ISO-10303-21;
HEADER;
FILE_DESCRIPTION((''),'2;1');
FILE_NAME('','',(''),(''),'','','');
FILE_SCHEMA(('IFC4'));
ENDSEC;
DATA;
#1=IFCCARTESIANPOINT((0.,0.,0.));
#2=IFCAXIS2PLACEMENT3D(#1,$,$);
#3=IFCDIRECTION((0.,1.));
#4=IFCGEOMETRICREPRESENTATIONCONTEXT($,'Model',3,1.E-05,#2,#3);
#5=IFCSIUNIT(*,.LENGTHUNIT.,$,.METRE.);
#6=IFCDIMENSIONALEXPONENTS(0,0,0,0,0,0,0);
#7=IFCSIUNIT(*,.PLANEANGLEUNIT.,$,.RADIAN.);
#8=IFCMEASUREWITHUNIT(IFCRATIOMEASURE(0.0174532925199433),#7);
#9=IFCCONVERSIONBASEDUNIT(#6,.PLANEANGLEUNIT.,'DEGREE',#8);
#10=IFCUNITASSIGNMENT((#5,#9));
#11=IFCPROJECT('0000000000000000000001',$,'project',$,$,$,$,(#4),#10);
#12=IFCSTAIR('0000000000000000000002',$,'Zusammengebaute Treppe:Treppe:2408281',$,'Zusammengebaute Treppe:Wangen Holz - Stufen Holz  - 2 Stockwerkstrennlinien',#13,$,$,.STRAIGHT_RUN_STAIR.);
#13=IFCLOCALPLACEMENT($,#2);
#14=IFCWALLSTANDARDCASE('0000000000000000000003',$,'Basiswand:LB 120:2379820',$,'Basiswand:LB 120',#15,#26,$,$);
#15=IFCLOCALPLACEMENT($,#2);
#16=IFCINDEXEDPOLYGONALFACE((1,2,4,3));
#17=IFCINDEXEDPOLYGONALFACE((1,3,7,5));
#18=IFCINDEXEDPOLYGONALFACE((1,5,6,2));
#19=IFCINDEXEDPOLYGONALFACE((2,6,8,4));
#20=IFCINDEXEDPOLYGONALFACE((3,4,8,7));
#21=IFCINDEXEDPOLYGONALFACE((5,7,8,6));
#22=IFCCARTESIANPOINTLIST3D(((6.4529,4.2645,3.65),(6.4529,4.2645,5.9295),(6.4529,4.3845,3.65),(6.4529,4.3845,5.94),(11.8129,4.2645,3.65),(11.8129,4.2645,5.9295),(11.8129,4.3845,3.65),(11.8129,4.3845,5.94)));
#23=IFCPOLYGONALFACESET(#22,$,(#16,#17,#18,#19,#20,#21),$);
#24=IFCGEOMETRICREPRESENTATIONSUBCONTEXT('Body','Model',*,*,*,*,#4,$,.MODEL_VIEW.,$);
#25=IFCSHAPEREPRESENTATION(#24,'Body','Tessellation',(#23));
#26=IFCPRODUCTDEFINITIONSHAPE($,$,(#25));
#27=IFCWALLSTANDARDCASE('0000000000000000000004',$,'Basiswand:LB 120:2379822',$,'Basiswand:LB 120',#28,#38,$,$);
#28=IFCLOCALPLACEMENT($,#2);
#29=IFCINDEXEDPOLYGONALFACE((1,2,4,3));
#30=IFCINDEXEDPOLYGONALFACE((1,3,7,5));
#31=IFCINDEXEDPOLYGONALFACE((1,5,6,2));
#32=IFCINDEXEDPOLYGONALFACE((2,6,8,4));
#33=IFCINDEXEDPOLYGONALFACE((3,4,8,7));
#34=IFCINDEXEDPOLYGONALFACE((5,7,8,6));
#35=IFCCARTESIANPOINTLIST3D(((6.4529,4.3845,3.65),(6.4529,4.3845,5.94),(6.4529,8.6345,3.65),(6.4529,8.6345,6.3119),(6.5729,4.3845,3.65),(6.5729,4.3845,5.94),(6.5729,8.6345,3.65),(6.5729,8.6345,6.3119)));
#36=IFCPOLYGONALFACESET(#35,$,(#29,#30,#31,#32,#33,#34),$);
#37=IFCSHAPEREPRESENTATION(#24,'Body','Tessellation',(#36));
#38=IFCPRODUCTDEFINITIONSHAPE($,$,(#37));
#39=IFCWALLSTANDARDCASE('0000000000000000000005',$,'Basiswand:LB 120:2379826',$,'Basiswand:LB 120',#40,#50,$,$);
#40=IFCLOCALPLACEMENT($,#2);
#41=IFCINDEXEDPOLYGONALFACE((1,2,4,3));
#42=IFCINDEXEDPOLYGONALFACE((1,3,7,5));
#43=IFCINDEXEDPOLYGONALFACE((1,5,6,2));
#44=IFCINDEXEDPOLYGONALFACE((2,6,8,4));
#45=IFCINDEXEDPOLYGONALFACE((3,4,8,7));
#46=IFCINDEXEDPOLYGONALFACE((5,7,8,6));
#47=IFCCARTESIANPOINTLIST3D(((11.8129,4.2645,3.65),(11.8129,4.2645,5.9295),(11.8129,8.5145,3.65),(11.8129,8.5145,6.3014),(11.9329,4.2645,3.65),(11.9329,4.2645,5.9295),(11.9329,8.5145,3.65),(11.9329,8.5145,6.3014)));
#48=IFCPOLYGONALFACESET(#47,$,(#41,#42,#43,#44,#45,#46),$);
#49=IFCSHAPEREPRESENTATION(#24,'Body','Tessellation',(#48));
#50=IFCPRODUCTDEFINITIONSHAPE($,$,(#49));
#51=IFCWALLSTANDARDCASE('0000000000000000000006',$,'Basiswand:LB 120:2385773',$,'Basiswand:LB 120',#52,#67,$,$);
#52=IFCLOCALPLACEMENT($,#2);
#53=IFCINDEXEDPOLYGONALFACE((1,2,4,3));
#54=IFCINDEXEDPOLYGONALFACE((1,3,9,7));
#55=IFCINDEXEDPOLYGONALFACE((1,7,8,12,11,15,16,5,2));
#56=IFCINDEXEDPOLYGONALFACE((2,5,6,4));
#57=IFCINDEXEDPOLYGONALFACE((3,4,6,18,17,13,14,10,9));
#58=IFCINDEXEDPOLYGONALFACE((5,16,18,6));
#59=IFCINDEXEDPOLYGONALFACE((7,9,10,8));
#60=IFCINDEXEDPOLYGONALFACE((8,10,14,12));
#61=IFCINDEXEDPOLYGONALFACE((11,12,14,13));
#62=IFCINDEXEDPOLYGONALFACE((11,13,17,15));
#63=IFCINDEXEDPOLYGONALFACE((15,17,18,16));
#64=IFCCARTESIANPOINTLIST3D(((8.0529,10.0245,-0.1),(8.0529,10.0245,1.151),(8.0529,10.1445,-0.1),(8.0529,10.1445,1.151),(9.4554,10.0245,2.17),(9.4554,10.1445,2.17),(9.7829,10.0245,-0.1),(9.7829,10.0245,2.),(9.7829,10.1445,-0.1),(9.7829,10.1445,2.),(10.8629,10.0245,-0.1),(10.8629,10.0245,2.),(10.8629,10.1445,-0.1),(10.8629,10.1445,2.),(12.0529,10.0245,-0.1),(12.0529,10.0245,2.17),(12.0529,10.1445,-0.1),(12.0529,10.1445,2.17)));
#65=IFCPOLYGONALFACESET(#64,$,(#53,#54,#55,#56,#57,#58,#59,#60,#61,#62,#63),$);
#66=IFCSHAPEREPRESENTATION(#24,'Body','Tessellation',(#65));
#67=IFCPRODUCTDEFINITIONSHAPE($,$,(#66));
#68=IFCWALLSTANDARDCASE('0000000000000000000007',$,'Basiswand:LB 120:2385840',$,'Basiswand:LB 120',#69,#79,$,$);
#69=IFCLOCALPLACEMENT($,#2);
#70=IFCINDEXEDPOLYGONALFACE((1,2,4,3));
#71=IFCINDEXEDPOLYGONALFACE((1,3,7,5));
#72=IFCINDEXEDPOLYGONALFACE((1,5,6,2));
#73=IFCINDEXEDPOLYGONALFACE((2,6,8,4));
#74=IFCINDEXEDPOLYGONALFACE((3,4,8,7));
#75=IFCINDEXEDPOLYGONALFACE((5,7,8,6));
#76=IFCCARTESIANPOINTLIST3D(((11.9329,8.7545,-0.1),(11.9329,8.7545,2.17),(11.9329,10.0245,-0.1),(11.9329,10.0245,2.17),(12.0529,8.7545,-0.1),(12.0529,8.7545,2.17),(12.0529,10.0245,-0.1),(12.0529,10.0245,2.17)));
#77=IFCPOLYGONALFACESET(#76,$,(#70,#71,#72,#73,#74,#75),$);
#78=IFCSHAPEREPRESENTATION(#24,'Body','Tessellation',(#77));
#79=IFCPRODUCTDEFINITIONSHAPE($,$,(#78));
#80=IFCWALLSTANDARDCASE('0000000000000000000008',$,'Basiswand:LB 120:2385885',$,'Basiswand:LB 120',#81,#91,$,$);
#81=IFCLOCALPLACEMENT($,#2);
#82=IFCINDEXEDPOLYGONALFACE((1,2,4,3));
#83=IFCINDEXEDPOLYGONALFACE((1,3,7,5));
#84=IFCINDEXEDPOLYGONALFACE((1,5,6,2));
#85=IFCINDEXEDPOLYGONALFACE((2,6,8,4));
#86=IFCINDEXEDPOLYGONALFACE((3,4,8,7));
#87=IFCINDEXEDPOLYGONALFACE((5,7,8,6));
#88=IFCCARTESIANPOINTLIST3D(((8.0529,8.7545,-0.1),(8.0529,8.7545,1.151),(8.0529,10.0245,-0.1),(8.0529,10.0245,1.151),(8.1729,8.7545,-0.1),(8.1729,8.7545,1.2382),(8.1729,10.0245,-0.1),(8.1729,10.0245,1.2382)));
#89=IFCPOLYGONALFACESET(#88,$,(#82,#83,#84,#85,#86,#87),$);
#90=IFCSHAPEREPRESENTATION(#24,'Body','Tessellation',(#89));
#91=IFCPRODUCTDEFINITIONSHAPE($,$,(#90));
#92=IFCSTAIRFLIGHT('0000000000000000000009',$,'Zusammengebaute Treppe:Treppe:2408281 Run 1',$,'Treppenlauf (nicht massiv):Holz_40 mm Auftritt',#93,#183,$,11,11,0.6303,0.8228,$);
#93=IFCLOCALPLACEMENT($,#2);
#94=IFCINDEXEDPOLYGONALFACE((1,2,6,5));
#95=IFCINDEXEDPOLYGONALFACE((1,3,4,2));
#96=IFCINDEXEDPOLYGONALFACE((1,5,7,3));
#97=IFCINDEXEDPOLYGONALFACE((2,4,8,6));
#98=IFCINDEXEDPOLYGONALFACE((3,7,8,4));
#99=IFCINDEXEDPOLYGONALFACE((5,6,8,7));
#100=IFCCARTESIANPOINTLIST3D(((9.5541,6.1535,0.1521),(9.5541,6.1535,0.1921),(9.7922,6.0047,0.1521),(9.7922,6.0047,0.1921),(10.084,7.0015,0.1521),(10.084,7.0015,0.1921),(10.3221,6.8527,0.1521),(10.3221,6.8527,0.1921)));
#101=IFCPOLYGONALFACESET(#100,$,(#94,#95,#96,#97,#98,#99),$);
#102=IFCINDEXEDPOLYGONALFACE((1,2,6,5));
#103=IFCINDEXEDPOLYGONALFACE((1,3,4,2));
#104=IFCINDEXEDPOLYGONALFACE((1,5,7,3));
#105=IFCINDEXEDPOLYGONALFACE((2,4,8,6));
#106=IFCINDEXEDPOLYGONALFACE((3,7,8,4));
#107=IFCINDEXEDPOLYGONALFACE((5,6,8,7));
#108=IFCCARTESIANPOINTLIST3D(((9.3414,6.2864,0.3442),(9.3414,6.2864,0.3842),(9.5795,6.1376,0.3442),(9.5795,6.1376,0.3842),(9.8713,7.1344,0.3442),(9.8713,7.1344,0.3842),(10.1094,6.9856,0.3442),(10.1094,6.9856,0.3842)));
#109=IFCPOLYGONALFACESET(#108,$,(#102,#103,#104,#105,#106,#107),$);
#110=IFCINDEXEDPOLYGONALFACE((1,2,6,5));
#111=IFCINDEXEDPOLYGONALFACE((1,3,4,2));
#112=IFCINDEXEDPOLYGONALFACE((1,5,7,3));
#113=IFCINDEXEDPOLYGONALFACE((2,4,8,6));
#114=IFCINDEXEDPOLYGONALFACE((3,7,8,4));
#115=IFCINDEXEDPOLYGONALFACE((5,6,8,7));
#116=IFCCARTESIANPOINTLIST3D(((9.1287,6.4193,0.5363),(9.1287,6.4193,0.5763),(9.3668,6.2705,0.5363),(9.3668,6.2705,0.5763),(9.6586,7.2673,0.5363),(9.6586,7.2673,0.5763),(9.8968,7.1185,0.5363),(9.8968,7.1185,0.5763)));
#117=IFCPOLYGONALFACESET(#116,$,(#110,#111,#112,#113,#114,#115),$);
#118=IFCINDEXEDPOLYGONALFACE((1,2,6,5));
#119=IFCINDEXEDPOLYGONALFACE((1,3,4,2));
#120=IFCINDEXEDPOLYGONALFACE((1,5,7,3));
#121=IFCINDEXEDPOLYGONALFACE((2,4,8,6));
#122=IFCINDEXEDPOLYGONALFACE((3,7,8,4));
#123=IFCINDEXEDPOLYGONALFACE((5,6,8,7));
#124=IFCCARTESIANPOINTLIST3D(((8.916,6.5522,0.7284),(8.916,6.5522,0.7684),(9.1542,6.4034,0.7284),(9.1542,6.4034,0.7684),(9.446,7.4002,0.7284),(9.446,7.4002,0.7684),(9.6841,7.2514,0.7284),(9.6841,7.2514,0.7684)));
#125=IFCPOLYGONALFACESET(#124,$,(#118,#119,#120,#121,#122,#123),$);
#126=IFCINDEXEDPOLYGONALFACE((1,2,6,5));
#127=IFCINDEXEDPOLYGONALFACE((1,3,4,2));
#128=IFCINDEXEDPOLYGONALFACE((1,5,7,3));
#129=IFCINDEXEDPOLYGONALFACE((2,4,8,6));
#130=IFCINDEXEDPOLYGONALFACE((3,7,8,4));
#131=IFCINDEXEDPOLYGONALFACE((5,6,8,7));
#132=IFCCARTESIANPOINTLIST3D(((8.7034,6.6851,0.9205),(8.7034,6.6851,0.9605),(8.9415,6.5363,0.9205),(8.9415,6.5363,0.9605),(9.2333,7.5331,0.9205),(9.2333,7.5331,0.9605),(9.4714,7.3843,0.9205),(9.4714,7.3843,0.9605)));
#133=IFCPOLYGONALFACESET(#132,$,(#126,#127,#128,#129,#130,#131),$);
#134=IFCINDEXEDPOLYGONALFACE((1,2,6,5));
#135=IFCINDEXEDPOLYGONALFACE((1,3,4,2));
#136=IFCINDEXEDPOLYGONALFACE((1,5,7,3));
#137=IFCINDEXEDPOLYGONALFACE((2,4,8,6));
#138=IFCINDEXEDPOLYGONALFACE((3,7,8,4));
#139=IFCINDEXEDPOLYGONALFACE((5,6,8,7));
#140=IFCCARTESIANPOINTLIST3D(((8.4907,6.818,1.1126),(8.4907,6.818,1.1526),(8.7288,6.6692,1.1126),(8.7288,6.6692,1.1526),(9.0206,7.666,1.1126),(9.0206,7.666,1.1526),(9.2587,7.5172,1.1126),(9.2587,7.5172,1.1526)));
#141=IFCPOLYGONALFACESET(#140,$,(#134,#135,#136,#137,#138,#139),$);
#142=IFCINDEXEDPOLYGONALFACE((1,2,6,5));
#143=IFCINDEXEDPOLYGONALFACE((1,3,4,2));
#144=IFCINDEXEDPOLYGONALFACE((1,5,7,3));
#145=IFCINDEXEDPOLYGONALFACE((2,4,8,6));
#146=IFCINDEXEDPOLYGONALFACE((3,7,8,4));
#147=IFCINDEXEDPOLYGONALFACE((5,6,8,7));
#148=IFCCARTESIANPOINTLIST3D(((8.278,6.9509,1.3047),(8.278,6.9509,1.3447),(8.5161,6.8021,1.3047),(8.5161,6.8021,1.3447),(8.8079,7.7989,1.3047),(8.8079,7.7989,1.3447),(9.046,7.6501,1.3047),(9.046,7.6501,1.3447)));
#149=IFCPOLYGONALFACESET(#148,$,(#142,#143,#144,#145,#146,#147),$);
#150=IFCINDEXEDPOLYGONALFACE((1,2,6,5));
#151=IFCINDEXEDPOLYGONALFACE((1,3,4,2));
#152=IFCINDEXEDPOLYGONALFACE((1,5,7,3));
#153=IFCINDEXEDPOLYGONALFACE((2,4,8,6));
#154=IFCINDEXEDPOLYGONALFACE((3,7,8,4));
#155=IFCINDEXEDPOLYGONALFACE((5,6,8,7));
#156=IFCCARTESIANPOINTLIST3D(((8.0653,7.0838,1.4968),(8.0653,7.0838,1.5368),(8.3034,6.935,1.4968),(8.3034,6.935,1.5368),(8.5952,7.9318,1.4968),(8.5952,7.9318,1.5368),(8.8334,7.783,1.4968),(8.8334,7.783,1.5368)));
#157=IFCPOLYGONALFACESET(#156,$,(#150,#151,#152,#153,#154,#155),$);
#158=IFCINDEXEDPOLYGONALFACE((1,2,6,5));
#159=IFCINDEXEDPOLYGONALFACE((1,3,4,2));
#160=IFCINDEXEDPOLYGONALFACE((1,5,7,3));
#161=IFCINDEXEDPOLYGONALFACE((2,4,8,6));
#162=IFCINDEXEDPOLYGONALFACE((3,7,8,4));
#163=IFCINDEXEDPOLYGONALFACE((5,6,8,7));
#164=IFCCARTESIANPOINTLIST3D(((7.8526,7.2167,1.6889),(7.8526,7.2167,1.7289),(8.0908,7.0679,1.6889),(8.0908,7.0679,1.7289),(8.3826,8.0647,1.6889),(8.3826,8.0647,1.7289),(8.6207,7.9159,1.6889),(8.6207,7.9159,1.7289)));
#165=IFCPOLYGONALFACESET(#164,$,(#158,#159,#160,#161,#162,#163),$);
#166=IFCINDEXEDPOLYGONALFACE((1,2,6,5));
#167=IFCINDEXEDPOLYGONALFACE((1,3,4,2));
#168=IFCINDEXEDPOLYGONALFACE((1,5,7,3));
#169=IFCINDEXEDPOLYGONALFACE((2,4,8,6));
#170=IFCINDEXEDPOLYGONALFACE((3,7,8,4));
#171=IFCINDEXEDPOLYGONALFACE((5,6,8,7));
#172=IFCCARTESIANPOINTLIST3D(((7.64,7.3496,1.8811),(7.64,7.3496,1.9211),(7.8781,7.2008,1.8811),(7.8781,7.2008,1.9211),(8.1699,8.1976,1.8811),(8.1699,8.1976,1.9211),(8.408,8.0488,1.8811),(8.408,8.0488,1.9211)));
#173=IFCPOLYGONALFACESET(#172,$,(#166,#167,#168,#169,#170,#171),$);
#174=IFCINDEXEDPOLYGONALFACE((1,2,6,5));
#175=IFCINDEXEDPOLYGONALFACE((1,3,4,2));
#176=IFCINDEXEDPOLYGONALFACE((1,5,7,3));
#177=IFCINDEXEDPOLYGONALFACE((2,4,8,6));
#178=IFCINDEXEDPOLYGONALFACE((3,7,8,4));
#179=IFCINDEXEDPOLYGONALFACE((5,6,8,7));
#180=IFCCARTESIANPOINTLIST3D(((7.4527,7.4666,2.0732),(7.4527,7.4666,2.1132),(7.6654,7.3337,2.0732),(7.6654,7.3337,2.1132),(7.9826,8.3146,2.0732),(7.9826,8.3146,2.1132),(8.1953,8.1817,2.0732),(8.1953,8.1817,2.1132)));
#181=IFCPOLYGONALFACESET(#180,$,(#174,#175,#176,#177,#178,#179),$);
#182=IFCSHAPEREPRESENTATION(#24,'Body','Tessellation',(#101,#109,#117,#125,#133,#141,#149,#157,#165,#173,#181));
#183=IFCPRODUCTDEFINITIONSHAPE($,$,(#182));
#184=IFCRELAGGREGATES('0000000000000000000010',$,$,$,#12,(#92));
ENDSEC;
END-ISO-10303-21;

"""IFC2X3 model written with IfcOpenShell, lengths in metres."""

from ifc_helpers import new_model, entity, si_unit, converted_unit, direction, frame, frame_2d, origin, place, context, subcontext, project, polyline, rectangle, extrude, clip, bounded_halfspace, element, aggregate, save


model = new_model("IFC2X3")

# Units and contexts
model_context = context("Model", 3, precision=1e-05, world=origin(), true_north=direction((0.0, 1.0)))
body_context = subcontext(model_context, "Body", "Model", "MODEL_VIEW")
ifc_project = project(units=[si_unit("LENGTHUNIT", "METRE"), converted_unit("PLANEANGLEUNIT", "DEGREE", entity("IfcRatioMeasure", 0.0174532925199433), si_unit("PLANEANGLEUNIT", "RADIAN"), dimensions=[0, 0, 0, 0, 0, 0, 0])], contexts=[model_context])

# Stair
placement_1 = place(None, origin())
placement_2 = place(placement_1, origin())
placement_3 = place(placement_2, origin())
stair_placement = place(placement_3, origin())
stair = element("IfcStair", 1, at=stair_placement, Name="Zusammengebaute Treppe:Treppe:2408281", ObjectType="Zusammengebaute Treppe:Wangen Holz - Stufen Holz  - 2 Stockwerkstrennlinien", ShapeType="STRAIGHT_RUN_STAIR")

# Shared definitions
placement_4 = place(placement_2, frame((0.0, 0.0, 3.65)))

# Walls
wall_1_placement = place(placement_4, frame((6.4529, 4.3245, 0.0)))
element("IfcWallStandardCase", 2, at=wall_1_placement, Name="Basiswand:LB 120:2379820", ObjectType="Basiswand:LB 120", context=body_context, shape_type="Clipping", body=[
    clip(extrude(rectangle(XDim=5.36, YDim=0.12, at=frame_2d((2.68, 0.0), x_axis=(-1.0, 0.0))), origin(), (0.0, 0.0, 1.0), 2.29), bounded_halfspace(frame((0.0, -0.06, 2.2795), z_axis=(0.0, -0.087156, 0.996195), x_axis=(1.0, 0.0, 0.0)), False, frame((0.0, -0.06, 2.2795)), polyline([(0.0, 0.0), (5.36, 0.0), (5.36, 0.12), (0.12, 0.12), (0.0, 0.12), (0.0, 0.0)]))),
])
wall_2_placement = place(placement_4, frame((6.5129, 8.6345, 0.0), z_axis=(0.0, 0.0, 1.0), x_axis=(0.0, -1.0, 0.0)))
element("IfcWallStandardCase", 3, at=wall_2_placement, Name="Basiswand:LB 120:2379822", ObjectType="Basiswand:LB 120", context=body_context, shape_type="Clipping", body=[
    clip(extrude(rectangle(XDim=4.25, YDim=0.12, at=frame_2d((2.125, 0.0), x_axis=(-1.0, 0.0))), origin(), (0.0, 0.0, 1.0), 2.6619), bounded_halfspace(frame((0.0, -0.06, 2.6619), z_axis=(0.087156, 0.0, 0.996195), x_axis=(0.0, 1.0, 0.0)), False, frame((0.0, -0.06, 2.6619)), polyline([(0.0, 0.0), (4.25, 0.0), (4.25, 0.12), (0.12, 0.12), (0.0, 0.12), (0.0, 0.0)]))),
])
wall_3_placement = place(placement_4, frame((11.8729, 4.2645, 0.0), z_axis=(0.0, 0.0, 1.0), x_axis=(0.0, 1.0, 0.0)))
element("IfcWallStandardCase", 4, at=wall_3_placement, Name="Basiswand:LB 120:2379826", ObjectType="Basiswand:LB 120", context=body_context, shape_type="Clipping", body=[
    clip(extrude(rectangle(XDim=4.25, YDim=0.12, at=frame_2d((2.125, 0.0), x_axis=(-1.0, 0.0))), origin(), (0.0, 0.0, 1.0), 2.6514), bounded_halfspace(frame((0.0, -0.06, 2.2795), z_axis=(-0.087156, 0.0, 0.996195), x_axis=(0.0, -1.0, 0.0)), False, frame((0.0, -0.06, 2.2795)), polyline([(0.0, 0.0), (4.25, 0.0), (4.25, 0.12), (0.12, 0.12), (0.0, 0.12), (0.0, 0.0)]))),
])

# Wall, opening
wall_4_placement = place(placement_3, frame((12.0529, 10.0845, -0.1), z_axis=(0.0, 0.0, 1.0), x_axis=(-1.0, 0.0, 0.0)))
wall_4 = element("IfcWallStandardCase", 5, at=wall_4_placement, Name="Basiswand:LB 120:2385773", ObjectType="Basiswand:LB 120", context=body_context, shape_type="Clipping", body=[
    clip(clip(extrude(rectangle(XDim=4.0, YDim=0.12, at=frame_2d((2.0, 0.0), x_axis=(-1.0, 0.0))), origin(), (0.0, 0.0, 1.0), 2.27), bounded_halfspace(frame((0.0, 0.06, 2.27), z_axis=(0.0, 0.0, -1.0), x_axis=(0.0, 1.0, 0.0)), True, frame((0.0, 0.06, 2.27)), polyline([(0.0, 0.0), (0.0, -0.12), (2.5975, -0.12), (2.5975, 0.0), (0.12, 0.0), (0.0, 0.0)]))), bounded_halfspace(frame((4.0, -0.06, 1.251), z_axis=(-0.587785, 0.0, -0.809017), x_axis=(0.0, 1.0, 0.0)), True, frame((4.0, -0.06, 1.251)), polyline([(0.0, 0.0), (0.0, 0.12), (-0.12, 0.12), (-1.4025, 0.12), (-1.4025, 0.0), (0.0, 0.0)]))),
])
opening_placement = place(wall_4_placement, frame((1.19, -0.06, 0.0)))
element("IfcOpeningElement", 6, at=opening_placement, cuts=wall_4, ObjectType="Opening", context=body_context, shape_type="SweptSolid", body=[
    extrude(rectangle(XDim=2.1, YDim=1.08, at=frame_2d((1.05, 0.54), x_axis=(-1.0, 0.0))), frame((0.0, 0.0, 0.0), z_axis=(0.0, 1.0, 0.0), x_axis=(0.0, 0.0, 1.0)), (0.0, 0.0, 1.0), 0.12),
])

# Walls
wall_5_placement = place(placement_3, frame((11.9929, 8.7545, -0.1), z_axis=(0.0, 0.0, 1.0), x_axis=(0.0, 1.0, 0.0)))
element("IfcWallStandardCase", 7, at=wall_5_placement, Name="Basiswand:LB 120:2385840", ObjectType="Basiswand:LB 120", context=body_context, shape_type="Clipping", body=[
    clip(extrude(rectangle(XDim=1.27, YDim=0.12, at=frame_2d((0.635, 0.0), x_axis=(-1.0, 0.0))), origin(), (0.0, 0.0, 1.0), 2.27), bounded_halfspace(frame((0.0, -0.06, 2.27), z_axis=(0.0, 0.0, -1.0), x_axis=(-1.0, 0.0, 0.0)), True, frame((0.0, -0.06, 2.27)), polyline([(0.0, 0.0), (1.27, 0.0), (1.27, 0.12), (0.0, 0.12), (0.0, 0.0)]))),
])
wall_6_placement = place(placement_3, frame((8.1129, 8.7545, -0.1), z_axis=(0.0, 0.0, 1.0), x_axis=(0.0, 1.0, 0.0)))
element("IfcWallStandardCase", 8, at=wall_6_placement, Name="Basiswand:LB 120:2385885", ObjectType="Basiswand:LB 120", context=body_context, shape_type="Clipping", body=[
    clip(extrude(rectangle(XDim=1.27, YDim=0.12, at=frame_2d((0.635, 0.0), x_axis=(-1.0, 0.0))), origin(), (0.0, 0.0, 1.0), 1.3382), bounded_halfspace(frame((0.0, -0.06, 1.3382), z_axis=(0.0, -0.587785, -0.809017), x_axis=(-1.0, 0.0, 0.0)), True, frame((0.0, -0.06, 1.3382)), polyline([(0.0, 0.0), (1.27, 0.0), (1.27, 0.12), (0.0, 0.12), (0.0, 0.0)]))),
])

# Stair flight
stair_flight_placement = place(stair_placement, origin())
stair_flight = element("IfcStairFlight", 9, at=stair_flight_placement, Name="Zusammengebaute Treppe:Treppe:2408281 Run 1", ObjectType="Treppenlauf (nicht massiv):Holz_40 mm Auftritt", NumberOfRiser=11, NumberOfTreads=11, RiserHeight=0.6303, TreadLength=0.8228, context=body_context, shape_type="SweptSolid", body=[
    extrude(rectangle(XDim=0.2808, YDim=1.0, at=frame_2d((0.0, 0.0), x_axis=(1.0, 0.0))), frame((9.9381, 6.5031, 0.1521), z_axis=(0.0, 0.0, 1.0), x_axis=(0.848048, -0.529919, 0.0)), (0.0, 0.0, 1.0), 0.04),
    extrude(rectangle(XDim=0.2808, YDim=1.0, at=frame_2d((0.0, 0.0), x_axis=(1.0, 0.0))), frame((9.7254, 6.636, 0.3442), z_axis=(0.0, 0.0, 1.0), x_axis=(0.848048, -0.529919, 0.0)), (0.0, 0.0, 1.0), 0.04),
    extrude(rectangle(XDim=0.2808, YDim=1.0, at=frame_2d((0.0, 0.0), x_axis=(1.0, 0.0))), frame((9.5127, 6.7689, 0.5363), z_axis=(0.0, 0.0, 1.0), x_axis=(0.848048, -0.529919, 0.0)), (0.0, 0.0, 1.0), 0.04),
    extrude(rectangle(XDim=0.2808, YDim=1.0, at=frame_2d((0.0, 0.0), x_axis=(1.0, 0.0))), frame((9.3001, 6.9018, 0.7284), z_axis=(0.0, 0.0, 1.0), x_axis=(0.848048, -0.529919, 0.0)), (0.0, 0.0, 1.0), 0.04),
    extrude(rectangle(XDim=0.2808, YDim=1.0, at=frame_2d((0.0, 0.0), x_axis=(1.0, 0.0))), frame((9.0874, 7.0347, 0.9205), z_axis=(0.0, 0.0, 1.0), x_axis=(0.848048, -0.529919, 0.0)), (0.0, 0.0, 1.0), 0.04),
    extrude(rectangle(XDim=0.2808, YDim=1.0, at=frame_2d((0.0, 0.0), x_axis=(1.0, 0.0))), frame((8.8747, 7.1676, 1.1126), z_axis=(0.0, 0.0, 1.0), x_axis=(0.848048, -0.529919, 0.0)), (0.0, 0.0, 1.0), 0.04),
    extrude(rectangle(XDim=0.2808, YDim=1.0, at=frame_2d((0.0, 0.0), x_axis=(1.0, 0.0))), frame((8.662, 7.3005, 1.3047), z_axis=(0.0, 0.0, 1.0), x_axis=(0.848048, -0.529919, 0.0)), (0.0, 0.0, 1.0), 0.04),
    extrude(rectangle(XDim=0.2808, YDim=1.0, at=frame_2d((0.0, 0.0), x_axis=(1.0, 0.0))), frame((8.4493, 7.4334, 1.4968), z_axis=(0.0, 0.0, 1.0), x_axis=(0.848048, -0.529919, 0.0)), (0.0, 0.0, 1.0), 0.04),
    extrude(rectangle(XDim=0.2808, YDim=1.0, at=frame_2d((0.0, 0.0), x_axis=(1.0, 0.0))), frame((8.2367, 7.5663, 1.6889), z_axis=(0.0, 0.0, 1.0), x_axis=(0.848048, -0.529919, 0.0)), (0.0, 0.0, 1.0), 0.04),
    extrude(rectangle(XDim=0.2808, YDim=1.0, at=frame_2d((0.0, 0.0), x_axis=(1.0, 0.0))), frame((8.024, 7.6992, 1.8811), z_axis=(0.0, 0.0, 1.0), x_axis=(0.848048, -0.529919, 0.0)), (0.0, 0.0, 1.0), 0.04),
    extrude(rectangle(XDim=0.2508, YDim=1.0, at=frame_2d((0.0, 0.0), x_axis=(1.0, 0.0))), frame((7.824, 7.8241, 2.0732), z_axis=(0.0, 0.0, 1.0), x_axis=(0.848048, -0.529919, 0.0)), (0.0, 0.0, 1.0), 0.04),
])
aggregate(stair, [stair_flight])

save(model, "model.ifc")
